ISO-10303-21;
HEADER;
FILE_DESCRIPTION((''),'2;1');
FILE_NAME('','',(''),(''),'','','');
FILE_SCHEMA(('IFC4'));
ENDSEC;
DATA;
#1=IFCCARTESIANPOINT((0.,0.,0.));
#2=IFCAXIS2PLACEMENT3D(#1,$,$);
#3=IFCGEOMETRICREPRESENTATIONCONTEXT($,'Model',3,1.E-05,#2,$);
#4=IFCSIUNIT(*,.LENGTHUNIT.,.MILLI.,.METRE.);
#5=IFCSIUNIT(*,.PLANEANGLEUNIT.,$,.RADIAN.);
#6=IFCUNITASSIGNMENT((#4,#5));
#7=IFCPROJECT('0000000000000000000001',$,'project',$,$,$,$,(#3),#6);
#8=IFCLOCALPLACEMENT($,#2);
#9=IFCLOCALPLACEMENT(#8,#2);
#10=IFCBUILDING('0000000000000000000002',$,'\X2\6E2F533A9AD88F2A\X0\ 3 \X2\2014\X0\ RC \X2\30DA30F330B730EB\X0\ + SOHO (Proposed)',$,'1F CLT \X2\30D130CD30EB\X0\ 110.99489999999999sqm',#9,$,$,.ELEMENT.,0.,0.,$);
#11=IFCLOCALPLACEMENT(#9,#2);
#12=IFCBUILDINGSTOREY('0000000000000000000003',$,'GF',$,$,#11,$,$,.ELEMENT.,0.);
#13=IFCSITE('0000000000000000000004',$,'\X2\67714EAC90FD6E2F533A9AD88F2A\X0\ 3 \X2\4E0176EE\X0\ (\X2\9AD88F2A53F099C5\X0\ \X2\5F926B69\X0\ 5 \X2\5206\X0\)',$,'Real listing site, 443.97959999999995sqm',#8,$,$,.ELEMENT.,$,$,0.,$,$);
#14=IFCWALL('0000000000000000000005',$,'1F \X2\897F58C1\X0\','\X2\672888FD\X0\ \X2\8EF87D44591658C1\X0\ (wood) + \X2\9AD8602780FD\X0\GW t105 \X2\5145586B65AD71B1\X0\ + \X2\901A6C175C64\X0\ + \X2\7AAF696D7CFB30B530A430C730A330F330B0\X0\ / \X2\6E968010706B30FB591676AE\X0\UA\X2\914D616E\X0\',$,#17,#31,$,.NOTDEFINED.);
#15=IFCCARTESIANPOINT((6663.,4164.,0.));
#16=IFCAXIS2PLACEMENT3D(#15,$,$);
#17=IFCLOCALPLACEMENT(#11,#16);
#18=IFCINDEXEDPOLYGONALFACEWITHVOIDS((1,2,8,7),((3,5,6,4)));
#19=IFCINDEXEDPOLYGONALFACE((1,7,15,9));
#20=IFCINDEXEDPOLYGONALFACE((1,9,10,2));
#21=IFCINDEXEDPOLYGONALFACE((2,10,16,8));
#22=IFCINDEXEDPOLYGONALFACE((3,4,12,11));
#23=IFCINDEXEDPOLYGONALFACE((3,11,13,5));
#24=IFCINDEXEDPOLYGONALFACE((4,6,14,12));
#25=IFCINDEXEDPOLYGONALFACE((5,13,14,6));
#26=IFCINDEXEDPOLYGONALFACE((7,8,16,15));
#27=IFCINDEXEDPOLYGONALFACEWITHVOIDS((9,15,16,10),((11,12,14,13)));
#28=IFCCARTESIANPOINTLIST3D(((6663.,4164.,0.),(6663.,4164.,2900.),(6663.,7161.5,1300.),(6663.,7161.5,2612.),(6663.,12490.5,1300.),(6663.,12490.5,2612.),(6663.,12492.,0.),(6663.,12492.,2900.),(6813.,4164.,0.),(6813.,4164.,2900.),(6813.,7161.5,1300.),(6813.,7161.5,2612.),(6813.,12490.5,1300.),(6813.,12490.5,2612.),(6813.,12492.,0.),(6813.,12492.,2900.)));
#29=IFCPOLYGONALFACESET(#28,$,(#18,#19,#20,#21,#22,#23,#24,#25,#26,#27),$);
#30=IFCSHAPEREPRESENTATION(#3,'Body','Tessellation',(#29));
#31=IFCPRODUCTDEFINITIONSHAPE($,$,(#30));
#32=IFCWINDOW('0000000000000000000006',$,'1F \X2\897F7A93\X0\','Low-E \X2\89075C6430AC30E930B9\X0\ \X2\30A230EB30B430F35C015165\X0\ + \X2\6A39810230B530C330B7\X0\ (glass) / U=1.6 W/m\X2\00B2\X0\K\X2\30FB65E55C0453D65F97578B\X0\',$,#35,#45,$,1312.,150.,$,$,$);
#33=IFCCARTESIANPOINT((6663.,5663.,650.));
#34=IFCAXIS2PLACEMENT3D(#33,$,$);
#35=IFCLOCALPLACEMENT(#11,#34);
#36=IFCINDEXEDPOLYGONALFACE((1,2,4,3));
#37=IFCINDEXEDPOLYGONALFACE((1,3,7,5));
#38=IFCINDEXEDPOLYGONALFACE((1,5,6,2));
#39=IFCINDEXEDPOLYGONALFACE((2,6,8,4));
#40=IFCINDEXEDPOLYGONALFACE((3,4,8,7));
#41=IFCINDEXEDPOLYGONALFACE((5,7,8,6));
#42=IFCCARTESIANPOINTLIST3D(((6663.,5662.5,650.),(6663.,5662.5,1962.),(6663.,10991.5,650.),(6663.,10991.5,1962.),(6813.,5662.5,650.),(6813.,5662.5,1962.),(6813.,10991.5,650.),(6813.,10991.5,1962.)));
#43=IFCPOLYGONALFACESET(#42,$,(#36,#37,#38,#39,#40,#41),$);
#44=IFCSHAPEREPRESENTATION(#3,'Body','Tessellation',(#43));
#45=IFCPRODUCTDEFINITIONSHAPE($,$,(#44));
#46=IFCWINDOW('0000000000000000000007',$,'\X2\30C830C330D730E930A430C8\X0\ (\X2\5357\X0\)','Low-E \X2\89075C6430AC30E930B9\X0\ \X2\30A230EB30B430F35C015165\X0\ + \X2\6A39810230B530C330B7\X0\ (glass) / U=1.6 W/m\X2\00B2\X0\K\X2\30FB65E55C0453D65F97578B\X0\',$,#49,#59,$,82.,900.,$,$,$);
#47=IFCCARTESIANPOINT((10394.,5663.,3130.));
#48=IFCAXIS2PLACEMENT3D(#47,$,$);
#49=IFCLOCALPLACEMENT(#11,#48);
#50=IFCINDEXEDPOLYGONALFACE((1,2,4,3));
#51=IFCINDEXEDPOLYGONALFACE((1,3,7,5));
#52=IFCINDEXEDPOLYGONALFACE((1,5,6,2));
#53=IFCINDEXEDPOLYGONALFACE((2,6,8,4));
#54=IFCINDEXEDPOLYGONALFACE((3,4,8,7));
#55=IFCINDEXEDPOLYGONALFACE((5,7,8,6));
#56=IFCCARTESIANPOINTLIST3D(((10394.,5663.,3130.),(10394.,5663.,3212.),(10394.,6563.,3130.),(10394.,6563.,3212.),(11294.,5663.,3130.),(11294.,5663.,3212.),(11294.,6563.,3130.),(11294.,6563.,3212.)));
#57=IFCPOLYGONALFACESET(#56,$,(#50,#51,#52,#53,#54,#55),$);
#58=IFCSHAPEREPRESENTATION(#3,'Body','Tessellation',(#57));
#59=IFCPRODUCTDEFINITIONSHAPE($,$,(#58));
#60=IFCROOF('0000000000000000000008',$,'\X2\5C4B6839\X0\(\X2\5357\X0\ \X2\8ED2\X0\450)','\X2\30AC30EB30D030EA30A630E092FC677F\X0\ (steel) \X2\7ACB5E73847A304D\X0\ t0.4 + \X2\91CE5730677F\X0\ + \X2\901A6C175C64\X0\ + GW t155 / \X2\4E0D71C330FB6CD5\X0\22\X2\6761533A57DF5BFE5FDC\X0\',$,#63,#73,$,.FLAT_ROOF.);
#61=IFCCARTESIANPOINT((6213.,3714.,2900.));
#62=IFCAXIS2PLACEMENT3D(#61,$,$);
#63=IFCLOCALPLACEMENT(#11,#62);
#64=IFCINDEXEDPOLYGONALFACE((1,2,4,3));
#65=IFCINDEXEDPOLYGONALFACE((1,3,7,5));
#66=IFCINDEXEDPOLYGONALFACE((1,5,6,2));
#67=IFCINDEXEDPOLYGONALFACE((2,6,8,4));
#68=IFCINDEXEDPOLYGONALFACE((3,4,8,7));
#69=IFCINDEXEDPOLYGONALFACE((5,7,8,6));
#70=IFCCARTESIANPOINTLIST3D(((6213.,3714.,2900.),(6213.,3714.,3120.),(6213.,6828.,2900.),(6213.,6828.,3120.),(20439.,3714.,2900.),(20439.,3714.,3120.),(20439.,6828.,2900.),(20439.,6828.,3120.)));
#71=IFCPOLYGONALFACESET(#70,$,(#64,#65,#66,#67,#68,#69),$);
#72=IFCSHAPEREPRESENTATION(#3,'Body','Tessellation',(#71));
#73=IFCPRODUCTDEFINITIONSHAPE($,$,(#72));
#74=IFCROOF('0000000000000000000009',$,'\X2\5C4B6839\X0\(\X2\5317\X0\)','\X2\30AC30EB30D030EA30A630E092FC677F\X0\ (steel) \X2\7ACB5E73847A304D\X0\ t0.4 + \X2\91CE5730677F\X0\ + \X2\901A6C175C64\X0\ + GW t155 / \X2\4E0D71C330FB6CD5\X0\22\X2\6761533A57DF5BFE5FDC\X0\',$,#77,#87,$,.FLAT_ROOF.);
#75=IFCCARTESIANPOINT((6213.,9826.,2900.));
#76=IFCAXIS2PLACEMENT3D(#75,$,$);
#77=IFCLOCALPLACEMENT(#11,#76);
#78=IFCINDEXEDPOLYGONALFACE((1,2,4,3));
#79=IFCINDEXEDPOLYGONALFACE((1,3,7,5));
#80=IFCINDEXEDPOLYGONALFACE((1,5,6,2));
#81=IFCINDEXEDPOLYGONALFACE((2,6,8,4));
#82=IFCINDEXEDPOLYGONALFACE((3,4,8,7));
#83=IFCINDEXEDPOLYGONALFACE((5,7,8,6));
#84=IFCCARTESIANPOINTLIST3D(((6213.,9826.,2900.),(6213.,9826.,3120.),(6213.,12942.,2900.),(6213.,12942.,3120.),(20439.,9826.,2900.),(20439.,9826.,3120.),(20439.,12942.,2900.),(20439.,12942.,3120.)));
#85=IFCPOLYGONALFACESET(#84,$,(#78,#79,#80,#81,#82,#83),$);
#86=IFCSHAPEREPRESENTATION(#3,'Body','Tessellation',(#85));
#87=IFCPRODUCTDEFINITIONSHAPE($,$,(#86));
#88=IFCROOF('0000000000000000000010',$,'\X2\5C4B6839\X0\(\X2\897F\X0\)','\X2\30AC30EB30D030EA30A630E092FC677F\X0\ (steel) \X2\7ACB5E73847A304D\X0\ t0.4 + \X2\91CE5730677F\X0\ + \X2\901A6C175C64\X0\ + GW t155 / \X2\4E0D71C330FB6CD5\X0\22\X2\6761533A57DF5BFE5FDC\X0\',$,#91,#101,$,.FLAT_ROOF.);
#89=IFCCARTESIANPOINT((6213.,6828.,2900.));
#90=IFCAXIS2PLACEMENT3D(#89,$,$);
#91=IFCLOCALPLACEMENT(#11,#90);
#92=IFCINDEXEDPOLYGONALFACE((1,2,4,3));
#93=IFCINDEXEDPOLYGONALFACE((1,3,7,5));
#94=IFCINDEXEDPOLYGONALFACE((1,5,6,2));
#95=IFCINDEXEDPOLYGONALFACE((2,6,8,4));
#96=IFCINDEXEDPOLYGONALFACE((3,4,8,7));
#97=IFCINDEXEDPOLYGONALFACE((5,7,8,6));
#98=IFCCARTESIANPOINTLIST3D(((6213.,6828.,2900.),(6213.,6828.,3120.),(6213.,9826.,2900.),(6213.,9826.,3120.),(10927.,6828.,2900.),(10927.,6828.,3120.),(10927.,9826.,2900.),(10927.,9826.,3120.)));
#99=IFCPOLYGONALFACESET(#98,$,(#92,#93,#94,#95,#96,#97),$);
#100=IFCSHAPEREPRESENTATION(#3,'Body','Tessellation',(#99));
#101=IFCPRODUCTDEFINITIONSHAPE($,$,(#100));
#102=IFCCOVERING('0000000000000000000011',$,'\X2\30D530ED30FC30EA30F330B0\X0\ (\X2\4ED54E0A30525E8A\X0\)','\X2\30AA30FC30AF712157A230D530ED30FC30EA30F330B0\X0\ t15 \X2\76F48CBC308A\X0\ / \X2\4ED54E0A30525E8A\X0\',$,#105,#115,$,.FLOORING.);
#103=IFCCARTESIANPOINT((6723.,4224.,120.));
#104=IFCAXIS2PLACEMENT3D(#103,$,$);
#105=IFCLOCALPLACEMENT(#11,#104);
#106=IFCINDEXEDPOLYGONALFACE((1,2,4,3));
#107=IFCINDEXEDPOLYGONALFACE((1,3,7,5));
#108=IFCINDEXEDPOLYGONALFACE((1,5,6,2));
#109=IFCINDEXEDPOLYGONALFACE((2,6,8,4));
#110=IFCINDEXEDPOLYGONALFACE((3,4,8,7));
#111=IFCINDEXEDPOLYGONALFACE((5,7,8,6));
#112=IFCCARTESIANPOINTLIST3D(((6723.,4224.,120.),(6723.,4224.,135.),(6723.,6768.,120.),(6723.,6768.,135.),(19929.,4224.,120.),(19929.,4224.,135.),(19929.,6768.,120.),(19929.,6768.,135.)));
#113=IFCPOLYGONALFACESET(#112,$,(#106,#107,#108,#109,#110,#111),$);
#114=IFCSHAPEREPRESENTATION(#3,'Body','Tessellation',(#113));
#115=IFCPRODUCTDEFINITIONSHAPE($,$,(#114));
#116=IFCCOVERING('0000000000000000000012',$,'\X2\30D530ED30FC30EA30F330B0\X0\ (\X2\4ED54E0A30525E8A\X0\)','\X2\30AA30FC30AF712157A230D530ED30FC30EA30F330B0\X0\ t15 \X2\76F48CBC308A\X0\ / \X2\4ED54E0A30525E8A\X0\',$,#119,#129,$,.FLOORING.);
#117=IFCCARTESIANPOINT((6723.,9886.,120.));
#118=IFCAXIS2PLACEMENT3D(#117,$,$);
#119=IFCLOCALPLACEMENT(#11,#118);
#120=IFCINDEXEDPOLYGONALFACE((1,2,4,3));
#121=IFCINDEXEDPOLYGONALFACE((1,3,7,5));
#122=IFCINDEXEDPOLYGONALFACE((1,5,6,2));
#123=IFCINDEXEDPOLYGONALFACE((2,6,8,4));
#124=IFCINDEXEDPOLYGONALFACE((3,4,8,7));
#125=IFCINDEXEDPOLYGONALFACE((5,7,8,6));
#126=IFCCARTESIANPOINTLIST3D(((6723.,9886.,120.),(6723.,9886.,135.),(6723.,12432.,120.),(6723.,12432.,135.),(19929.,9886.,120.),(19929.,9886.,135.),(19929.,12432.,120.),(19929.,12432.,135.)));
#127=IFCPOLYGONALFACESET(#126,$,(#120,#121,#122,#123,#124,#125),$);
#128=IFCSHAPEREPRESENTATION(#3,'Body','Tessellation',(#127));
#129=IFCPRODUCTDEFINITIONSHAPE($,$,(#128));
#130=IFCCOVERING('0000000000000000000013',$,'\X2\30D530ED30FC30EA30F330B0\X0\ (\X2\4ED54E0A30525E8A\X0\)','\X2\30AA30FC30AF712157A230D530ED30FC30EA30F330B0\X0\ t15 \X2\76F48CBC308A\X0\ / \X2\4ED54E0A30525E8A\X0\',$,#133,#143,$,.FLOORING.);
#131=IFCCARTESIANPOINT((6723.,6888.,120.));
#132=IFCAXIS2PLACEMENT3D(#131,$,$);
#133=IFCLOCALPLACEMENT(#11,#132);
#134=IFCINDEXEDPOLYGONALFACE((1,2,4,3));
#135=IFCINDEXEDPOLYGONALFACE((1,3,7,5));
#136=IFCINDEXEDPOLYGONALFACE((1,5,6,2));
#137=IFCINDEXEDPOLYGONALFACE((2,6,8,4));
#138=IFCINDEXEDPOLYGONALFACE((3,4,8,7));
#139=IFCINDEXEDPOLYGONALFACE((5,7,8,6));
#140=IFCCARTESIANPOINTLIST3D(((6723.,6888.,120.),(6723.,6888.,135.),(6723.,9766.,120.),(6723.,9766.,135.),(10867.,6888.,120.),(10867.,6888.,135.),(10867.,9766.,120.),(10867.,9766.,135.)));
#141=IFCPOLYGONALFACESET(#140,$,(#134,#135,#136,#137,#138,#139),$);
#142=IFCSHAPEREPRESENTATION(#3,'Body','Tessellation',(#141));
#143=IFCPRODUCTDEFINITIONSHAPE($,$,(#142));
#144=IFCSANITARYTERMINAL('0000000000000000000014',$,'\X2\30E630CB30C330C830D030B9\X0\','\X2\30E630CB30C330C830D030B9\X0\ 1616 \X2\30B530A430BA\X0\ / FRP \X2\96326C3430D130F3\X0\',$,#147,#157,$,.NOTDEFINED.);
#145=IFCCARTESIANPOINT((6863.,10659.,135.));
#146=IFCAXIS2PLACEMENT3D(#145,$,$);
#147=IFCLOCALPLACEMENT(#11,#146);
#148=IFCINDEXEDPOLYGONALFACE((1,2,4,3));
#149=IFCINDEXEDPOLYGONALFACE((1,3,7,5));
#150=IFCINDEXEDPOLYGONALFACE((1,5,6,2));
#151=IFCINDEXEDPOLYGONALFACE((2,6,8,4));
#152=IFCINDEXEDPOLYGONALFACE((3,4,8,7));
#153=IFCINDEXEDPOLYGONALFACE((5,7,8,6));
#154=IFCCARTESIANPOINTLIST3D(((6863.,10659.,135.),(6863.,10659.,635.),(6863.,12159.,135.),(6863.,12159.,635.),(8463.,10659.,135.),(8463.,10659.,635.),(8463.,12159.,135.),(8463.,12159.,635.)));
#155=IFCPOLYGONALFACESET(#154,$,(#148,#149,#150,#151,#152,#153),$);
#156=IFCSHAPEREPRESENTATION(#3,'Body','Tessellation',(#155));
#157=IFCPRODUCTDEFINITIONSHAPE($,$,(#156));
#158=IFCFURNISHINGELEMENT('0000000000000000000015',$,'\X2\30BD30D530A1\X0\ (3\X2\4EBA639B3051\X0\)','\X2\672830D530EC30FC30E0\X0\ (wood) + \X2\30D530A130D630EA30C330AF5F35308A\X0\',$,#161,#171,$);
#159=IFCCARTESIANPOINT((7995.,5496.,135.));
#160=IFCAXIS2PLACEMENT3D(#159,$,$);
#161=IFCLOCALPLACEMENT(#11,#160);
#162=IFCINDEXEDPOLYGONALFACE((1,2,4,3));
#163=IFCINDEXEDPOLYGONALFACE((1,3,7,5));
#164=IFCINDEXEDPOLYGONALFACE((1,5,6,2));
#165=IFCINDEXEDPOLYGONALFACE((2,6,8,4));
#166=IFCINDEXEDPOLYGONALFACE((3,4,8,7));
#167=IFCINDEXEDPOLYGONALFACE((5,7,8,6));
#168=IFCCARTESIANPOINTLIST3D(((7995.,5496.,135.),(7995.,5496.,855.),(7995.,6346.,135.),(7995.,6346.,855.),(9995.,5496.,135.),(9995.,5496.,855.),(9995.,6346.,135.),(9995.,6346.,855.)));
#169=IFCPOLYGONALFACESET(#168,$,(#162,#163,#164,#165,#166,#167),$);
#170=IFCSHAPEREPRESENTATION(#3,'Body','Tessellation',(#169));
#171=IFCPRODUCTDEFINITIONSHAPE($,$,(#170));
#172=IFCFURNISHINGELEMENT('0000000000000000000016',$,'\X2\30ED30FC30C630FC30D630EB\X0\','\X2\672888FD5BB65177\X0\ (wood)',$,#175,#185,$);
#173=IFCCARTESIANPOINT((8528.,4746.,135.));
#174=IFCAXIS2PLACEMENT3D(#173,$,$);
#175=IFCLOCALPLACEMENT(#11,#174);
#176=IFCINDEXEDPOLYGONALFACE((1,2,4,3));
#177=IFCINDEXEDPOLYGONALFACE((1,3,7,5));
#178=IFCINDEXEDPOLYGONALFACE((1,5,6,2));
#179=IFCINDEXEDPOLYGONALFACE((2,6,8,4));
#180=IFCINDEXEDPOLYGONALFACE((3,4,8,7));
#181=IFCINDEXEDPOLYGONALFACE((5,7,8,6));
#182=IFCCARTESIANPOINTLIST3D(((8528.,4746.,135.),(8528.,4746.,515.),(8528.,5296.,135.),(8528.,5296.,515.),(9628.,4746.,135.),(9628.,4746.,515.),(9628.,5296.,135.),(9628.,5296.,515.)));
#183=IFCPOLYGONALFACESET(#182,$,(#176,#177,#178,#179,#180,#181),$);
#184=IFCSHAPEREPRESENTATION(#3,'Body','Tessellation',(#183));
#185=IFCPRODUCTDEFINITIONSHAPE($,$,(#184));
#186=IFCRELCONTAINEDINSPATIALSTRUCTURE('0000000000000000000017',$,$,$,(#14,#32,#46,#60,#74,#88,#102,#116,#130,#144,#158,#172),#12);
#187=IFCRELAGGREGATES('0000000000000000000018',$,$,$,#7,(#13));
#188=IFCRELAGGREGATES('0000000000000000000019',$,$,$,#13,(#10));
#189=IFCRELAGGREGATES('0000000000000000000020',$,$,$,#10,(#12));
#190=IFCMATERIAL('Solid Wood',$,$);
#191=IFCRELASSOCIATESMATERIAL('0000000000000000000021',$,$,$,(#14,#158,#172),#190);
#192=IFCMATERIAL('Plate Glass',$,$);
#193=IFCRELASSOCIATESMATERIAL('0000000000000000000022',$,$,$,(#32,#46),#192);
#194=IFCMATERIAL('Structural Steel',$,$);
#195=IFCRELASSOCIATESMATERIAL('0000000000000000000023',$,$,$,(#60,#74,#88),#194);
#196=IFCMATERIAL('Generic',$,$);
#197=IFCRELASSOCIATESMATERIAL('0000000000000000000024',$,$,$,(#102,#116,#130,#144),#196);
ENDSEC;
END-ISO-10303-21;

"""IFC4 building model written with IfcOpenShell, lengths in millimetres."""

from ifc_helpers import new_model, si_unit, frame, frame_2d, origin, place, context, project, spatial, rectangle, extrude, material, element, fill, save


model = new_model("IFC4")

# Units and contexts
model_context = context("Model", 3, precision=1e-05, world=origin())
ifc_project = project(units=[si_unit("LENGTHUNIT", "METRE", prefix="MILLI"), si_unit("PLANEANGLEUNIT", "RADIAN")], contexts=[model_context])

# Site, building, storey
site_placement = place(None, origin())
site = spatial("IfcSite", under=ifc_project, at=site_placement, Name="東京都港区高輪 3 丁目 (高輪台駅 徒歩 5 分)", ObjectType="Real listing site, 443.97959999999995sqm", CompositionType="ELEMENT", RefElevation=0.0)
building_placement = place(site_placement, origin())
building = spatial("IfcBuilding", under=site, at=building_placement, Name="港区高輪 3 — RC ペンシル + SOHO (Proposed)", ObjectType="1F CLT パネル 110.99489999999999sqm", CompositionType="ELEMENT", ElevationOfRefHeight=0.0, ElevationOfTerrain=0.0)
storey_placement = place(building_placement, origin())
storey = spatial("IfcBuildingStorey", under=building, at=storey_placement, Name="GF", CompositionType="ELEMENT", Elevation=0.0)

# Shared definitions
ifc_material_1 = material(Name="Solid Wood")

# Shared definitions
ifc_material_2 = material(Name="Plate Glass")

# Wall, opening, window
wall_1_placement = place(storey_placement, frame((6663.0, 4164.0, 0.0)))
wall_1 = element("IfcWall", 1, at=wall_1_placement, inside=storey, material=ifc_material_1, Name="1F 西壁", Description="木製 軸組外壁 (wood) + 高性能GW t105 充填断熱 + 通気層 + 窯業系サイディング / 準耐火・外皮UA配慮", PredefinedType="NOTDEFINED", context=model_context, shape_type="SweptSolid", body=[
    extrude(rectangle(XDim=150.0, YDim=8328.0, at=frame_2d((75.0, 4164.0))), frame((6663.0, 4164.0, 0.0)), (0.0, 0.0, 1.0), 2900.0),
])
opening_1_placement = place(storey_placement, frame((6663.0, 5663.0, 650.0)))
opening_1 = element("IfcOpeningElement", 2, at=opening_1_placement, cuts=wall_1, PredefinedType="NOTDEFINED", context=model_context, shape_type="SweptSolid", body=[
    extrude(rectangle(XDim=150.0, YDim=5329.0, at=frame_2d((75.0, 2664.0))), frame((6663.0, 5663.0, 650.0)), (0.0, 0.0, 1.0), 1312.0),
])
window_1_placement = place(storey_placement, frame((6663.0, 5663.0, 650.0)))
window_1 = element("IfcWindow", 3, at=window_1_placement, inside=storey, material=ifc_material_2, Name="1F 西窓", Description="Low-E 複層ガラス アルゴン封入 + 樹脂サッシ (glass) / U=1.6 W/m²K・日射取得型", OverallHeight=1312.0, OverallWidth=150.0, context=model_context, shape_type="SweptSolid", body=[
    extrude(rectangle(XDim=150.0, YDim=5329.0, at=frame_2d((75.0, 2664.0))), frame((6663.0, 5663.0, 650.0)), (0.0, 0.0, 1.0), 1312.0),
])
fill(opening_1, window_1)

# Window
window_2_placement = place(storey_placement, frame((10394.0, 5663.0, 3130.0)))
element("IfcWindow", 4, at=window_2_placement, inside=storey, material=ifc_material_2, Name="トップライト (南)", Description="Low-E 複層ガラス アルゴン封入 + 樹脂サッシ (glass) / U=1.6 W/m²K・日射取得型", OverallHeight=82.0, OverallWidth=900.0, context=model_context, shape_type="SweptSolid", body=[
    extrude(rectangle(XDim=900.0, YDim=900.0, at=frame_2d((450.0, 450.0))), frame((10394.0, 5663.0, 3130.0)), (0.0, 0.0, 1.0), 82.0),
])

# Roofs
ifc_material_3 = material(Name="Structural Steel")
roof_1_placement = place(storey_placement, frame((6213.0, 3714.0, 2900.0)))
element("IfcRoof", 5, at=roof_1_placement, inside=storey, material=ifc_material_3, Name="屋根(南 軒450)", Description="ガルバリウム鋼板 (steel) 立平葺き t0.4 + 野地板 + 通気層 + GW t155 / 不燃・法22条区域対応", PredefinedType="FLAT_ROOF", context=model_context, shape_type="SweptSolid", body=[
    extrude(rectangle(XDim=14226.0, YDim=3114.0, at=frame_2d((7113.0, 1557.0))), frame((6213.0, 3714.0, 2900.0)), (0.0, 0.0, 1.0), 220.0),
])
roof_2_placement = place(storey_placement, frame((6213.0, 9826.0, 2900.0)))
element("IfcRoof", 6, at=roof_2_placement, inside=storey, material=ifc_material_3, Name="屋根(北)", Description="ガルバリウム鋼板 (steel) 立平葺き t0.4 + 野地板 + 通気層 + GW t155 / 不燃・法22条区域対応", PredefinedType="FLAT_ROOF", context=model_context, shape_type="SweptSolid", body=[
    extrude(rectangle(XDim=14226.0, YDim=3116.0, at=frame_2d((7113.0, 1558.0))), frame((6213.0, 9826.0, 2900.0)), (0.0, 0.0, 1.0), 220.0),
])
roof_3_placement = place(storey_placement, frame((6213.0, 6828.0, 2900.0)))
element("IfcRoof", 7, at=roof_3_placement, inside=storey, material=ifc_material_3, Name="屋根(西)", Description="ガルバリウム鋼板 (steel) 立平葺き t0.4 + 野地板 + 通気層 + GW t155 / 不燃・法22条区域対応", PredefinedType="FLAT_ROOF", context=model_context, shape_type="SweptSolid", body=[
    extrude(rectangle(XDim=4714.0, YDim=2998.0, at=frame_2d((2357.0, 1499.0))), frame((6213.0, 6828.0, 2900.0)), (0.0, 0.0, 1.0), 220.0),
])

# Coverings
ifc_material_4 = material(Name="Generic")
covering_1_placement = place(storey_placement, frame((6723.0, 4224.0, 120.0)))
element("IfcCovering", 8, at=covering_1_placement, inside=storey, material=ifc_material_4, Name="フローリング (仕上げ床)", Description="オーク無垢フローリング t15 直貼り / 仕上げ床", PredefinedType="FLOORING", context=model_context, shape_type="SweptSolid", body=[
    extrude(rectangle(XDim=13206.0, YDim=2544.0, at=frame_2d((6603.0, 1272.0))), frame((6723.0, 4224.0, 120.0)), (0.0, 0.0, 1.0), 15.0),
])
covering_2_placement = place(storey_placement, frame((6723.0, 9886.0, 120.0)))
element("IfcCovering", 9, at=covering_2_placement, inside=storey, material=ifc_material_4, Name="フローリング (仕上げ床)", Description="オーク無垢フローリング t15 直貼り / 仕上げ床", PredefinedType="FLOORING", context=model_context, shape_type="SweptSolid", body=[
    extrude(rectangle(XDim=13206.0, YDim=2546.0, at=frame_2d((6603.0, 1273.0))), frame((6723.0, 9886.0, 120.0)), (0.0, 0.0, 1.0), 15.0),
])
covering_3_placement = place(storey_placement, frame((6723.0, 6888.0, 120.0)))
element("IfcCovering", 10, at=covering_3_placement, inside=storey, material=ifc_material_4, Name="フローリング (仕上げ床)", Description="オーク無垢フローリング t15 直貼り / 仕上げ床", PredefinedType="FLOORING", context=model_context, shape_type="SweptSolid", body=[
    extrude(rectangle(XDim=4144.0, YDim=2878.0, at=frame_2d((2072.0, 1439.0))), frame((6723.0, 6888.0, 120.0)), (0.0, 0.0, 1.0), 15.0),
])

# Sanitary terminal
sanitary_terminal_placement = place(storey_placement, frame((6863.0, 10659.0, 135.0)))
element("IfcSanitaryTerminal", 11, at=sanitary_terminal_placement, inside=storey, material=ifc_material_4, Name="ユニットバス", Description="ユニットバス 1616 サイズ / FRP 防水パン", PredefinedType="NOTDEFINED", context=model_context, shape_type="SweptSolid", body=[
    extrude(rectangle(XDim=1600.0, YDim=1500.0, at=frame_2d((800.0, 750.0))), frame((6863.0, 10659.0, 135.0)), (0.0, 0.0, 1.0), 500.0),
])

# Furnishing elements
furnishing_1_placement = place(storey_placement, frame((7995.0, 5496.0, 135.0)))
element("IfcFurnishingElement", 12, at=furnishing_1_placement, inside=storey, material=ifc_material_1, Name="ソファ (3人掛け)", Description="木フレーム (wood) + ファブリック張り", context=model_context, shape_type="SweptSolid", body=[
    extrude(rectangle(XDim=2000.0, YDim=850.0, at=frame_2d((1000.0, 425.0))), frame((7995.0, 5496.0, 135.0)), (0.0, 0.0, 1.0), 720.0),
])
furnishing_2_placement = place(storey_placement, frame((8528.0, 4746.0, 135.0)))
element("IfcFurnishingElement", 13, at=furnishing_2_placement, inside=storey, material=ifc_material_1, Name="ローテーブル", Description="木製家具 (wood)", context=model_context, shape_type="SweptSolid", body=[
    extrude(rectangle(XDim=1100.0, YDim=550.0, at=frame_2d((550.0, 275.0))), frame((8528.0, 4746.0, 135.0)), (0.0, 0.0, 1.0), 380.0),
])

save(model, "model.ifc")
